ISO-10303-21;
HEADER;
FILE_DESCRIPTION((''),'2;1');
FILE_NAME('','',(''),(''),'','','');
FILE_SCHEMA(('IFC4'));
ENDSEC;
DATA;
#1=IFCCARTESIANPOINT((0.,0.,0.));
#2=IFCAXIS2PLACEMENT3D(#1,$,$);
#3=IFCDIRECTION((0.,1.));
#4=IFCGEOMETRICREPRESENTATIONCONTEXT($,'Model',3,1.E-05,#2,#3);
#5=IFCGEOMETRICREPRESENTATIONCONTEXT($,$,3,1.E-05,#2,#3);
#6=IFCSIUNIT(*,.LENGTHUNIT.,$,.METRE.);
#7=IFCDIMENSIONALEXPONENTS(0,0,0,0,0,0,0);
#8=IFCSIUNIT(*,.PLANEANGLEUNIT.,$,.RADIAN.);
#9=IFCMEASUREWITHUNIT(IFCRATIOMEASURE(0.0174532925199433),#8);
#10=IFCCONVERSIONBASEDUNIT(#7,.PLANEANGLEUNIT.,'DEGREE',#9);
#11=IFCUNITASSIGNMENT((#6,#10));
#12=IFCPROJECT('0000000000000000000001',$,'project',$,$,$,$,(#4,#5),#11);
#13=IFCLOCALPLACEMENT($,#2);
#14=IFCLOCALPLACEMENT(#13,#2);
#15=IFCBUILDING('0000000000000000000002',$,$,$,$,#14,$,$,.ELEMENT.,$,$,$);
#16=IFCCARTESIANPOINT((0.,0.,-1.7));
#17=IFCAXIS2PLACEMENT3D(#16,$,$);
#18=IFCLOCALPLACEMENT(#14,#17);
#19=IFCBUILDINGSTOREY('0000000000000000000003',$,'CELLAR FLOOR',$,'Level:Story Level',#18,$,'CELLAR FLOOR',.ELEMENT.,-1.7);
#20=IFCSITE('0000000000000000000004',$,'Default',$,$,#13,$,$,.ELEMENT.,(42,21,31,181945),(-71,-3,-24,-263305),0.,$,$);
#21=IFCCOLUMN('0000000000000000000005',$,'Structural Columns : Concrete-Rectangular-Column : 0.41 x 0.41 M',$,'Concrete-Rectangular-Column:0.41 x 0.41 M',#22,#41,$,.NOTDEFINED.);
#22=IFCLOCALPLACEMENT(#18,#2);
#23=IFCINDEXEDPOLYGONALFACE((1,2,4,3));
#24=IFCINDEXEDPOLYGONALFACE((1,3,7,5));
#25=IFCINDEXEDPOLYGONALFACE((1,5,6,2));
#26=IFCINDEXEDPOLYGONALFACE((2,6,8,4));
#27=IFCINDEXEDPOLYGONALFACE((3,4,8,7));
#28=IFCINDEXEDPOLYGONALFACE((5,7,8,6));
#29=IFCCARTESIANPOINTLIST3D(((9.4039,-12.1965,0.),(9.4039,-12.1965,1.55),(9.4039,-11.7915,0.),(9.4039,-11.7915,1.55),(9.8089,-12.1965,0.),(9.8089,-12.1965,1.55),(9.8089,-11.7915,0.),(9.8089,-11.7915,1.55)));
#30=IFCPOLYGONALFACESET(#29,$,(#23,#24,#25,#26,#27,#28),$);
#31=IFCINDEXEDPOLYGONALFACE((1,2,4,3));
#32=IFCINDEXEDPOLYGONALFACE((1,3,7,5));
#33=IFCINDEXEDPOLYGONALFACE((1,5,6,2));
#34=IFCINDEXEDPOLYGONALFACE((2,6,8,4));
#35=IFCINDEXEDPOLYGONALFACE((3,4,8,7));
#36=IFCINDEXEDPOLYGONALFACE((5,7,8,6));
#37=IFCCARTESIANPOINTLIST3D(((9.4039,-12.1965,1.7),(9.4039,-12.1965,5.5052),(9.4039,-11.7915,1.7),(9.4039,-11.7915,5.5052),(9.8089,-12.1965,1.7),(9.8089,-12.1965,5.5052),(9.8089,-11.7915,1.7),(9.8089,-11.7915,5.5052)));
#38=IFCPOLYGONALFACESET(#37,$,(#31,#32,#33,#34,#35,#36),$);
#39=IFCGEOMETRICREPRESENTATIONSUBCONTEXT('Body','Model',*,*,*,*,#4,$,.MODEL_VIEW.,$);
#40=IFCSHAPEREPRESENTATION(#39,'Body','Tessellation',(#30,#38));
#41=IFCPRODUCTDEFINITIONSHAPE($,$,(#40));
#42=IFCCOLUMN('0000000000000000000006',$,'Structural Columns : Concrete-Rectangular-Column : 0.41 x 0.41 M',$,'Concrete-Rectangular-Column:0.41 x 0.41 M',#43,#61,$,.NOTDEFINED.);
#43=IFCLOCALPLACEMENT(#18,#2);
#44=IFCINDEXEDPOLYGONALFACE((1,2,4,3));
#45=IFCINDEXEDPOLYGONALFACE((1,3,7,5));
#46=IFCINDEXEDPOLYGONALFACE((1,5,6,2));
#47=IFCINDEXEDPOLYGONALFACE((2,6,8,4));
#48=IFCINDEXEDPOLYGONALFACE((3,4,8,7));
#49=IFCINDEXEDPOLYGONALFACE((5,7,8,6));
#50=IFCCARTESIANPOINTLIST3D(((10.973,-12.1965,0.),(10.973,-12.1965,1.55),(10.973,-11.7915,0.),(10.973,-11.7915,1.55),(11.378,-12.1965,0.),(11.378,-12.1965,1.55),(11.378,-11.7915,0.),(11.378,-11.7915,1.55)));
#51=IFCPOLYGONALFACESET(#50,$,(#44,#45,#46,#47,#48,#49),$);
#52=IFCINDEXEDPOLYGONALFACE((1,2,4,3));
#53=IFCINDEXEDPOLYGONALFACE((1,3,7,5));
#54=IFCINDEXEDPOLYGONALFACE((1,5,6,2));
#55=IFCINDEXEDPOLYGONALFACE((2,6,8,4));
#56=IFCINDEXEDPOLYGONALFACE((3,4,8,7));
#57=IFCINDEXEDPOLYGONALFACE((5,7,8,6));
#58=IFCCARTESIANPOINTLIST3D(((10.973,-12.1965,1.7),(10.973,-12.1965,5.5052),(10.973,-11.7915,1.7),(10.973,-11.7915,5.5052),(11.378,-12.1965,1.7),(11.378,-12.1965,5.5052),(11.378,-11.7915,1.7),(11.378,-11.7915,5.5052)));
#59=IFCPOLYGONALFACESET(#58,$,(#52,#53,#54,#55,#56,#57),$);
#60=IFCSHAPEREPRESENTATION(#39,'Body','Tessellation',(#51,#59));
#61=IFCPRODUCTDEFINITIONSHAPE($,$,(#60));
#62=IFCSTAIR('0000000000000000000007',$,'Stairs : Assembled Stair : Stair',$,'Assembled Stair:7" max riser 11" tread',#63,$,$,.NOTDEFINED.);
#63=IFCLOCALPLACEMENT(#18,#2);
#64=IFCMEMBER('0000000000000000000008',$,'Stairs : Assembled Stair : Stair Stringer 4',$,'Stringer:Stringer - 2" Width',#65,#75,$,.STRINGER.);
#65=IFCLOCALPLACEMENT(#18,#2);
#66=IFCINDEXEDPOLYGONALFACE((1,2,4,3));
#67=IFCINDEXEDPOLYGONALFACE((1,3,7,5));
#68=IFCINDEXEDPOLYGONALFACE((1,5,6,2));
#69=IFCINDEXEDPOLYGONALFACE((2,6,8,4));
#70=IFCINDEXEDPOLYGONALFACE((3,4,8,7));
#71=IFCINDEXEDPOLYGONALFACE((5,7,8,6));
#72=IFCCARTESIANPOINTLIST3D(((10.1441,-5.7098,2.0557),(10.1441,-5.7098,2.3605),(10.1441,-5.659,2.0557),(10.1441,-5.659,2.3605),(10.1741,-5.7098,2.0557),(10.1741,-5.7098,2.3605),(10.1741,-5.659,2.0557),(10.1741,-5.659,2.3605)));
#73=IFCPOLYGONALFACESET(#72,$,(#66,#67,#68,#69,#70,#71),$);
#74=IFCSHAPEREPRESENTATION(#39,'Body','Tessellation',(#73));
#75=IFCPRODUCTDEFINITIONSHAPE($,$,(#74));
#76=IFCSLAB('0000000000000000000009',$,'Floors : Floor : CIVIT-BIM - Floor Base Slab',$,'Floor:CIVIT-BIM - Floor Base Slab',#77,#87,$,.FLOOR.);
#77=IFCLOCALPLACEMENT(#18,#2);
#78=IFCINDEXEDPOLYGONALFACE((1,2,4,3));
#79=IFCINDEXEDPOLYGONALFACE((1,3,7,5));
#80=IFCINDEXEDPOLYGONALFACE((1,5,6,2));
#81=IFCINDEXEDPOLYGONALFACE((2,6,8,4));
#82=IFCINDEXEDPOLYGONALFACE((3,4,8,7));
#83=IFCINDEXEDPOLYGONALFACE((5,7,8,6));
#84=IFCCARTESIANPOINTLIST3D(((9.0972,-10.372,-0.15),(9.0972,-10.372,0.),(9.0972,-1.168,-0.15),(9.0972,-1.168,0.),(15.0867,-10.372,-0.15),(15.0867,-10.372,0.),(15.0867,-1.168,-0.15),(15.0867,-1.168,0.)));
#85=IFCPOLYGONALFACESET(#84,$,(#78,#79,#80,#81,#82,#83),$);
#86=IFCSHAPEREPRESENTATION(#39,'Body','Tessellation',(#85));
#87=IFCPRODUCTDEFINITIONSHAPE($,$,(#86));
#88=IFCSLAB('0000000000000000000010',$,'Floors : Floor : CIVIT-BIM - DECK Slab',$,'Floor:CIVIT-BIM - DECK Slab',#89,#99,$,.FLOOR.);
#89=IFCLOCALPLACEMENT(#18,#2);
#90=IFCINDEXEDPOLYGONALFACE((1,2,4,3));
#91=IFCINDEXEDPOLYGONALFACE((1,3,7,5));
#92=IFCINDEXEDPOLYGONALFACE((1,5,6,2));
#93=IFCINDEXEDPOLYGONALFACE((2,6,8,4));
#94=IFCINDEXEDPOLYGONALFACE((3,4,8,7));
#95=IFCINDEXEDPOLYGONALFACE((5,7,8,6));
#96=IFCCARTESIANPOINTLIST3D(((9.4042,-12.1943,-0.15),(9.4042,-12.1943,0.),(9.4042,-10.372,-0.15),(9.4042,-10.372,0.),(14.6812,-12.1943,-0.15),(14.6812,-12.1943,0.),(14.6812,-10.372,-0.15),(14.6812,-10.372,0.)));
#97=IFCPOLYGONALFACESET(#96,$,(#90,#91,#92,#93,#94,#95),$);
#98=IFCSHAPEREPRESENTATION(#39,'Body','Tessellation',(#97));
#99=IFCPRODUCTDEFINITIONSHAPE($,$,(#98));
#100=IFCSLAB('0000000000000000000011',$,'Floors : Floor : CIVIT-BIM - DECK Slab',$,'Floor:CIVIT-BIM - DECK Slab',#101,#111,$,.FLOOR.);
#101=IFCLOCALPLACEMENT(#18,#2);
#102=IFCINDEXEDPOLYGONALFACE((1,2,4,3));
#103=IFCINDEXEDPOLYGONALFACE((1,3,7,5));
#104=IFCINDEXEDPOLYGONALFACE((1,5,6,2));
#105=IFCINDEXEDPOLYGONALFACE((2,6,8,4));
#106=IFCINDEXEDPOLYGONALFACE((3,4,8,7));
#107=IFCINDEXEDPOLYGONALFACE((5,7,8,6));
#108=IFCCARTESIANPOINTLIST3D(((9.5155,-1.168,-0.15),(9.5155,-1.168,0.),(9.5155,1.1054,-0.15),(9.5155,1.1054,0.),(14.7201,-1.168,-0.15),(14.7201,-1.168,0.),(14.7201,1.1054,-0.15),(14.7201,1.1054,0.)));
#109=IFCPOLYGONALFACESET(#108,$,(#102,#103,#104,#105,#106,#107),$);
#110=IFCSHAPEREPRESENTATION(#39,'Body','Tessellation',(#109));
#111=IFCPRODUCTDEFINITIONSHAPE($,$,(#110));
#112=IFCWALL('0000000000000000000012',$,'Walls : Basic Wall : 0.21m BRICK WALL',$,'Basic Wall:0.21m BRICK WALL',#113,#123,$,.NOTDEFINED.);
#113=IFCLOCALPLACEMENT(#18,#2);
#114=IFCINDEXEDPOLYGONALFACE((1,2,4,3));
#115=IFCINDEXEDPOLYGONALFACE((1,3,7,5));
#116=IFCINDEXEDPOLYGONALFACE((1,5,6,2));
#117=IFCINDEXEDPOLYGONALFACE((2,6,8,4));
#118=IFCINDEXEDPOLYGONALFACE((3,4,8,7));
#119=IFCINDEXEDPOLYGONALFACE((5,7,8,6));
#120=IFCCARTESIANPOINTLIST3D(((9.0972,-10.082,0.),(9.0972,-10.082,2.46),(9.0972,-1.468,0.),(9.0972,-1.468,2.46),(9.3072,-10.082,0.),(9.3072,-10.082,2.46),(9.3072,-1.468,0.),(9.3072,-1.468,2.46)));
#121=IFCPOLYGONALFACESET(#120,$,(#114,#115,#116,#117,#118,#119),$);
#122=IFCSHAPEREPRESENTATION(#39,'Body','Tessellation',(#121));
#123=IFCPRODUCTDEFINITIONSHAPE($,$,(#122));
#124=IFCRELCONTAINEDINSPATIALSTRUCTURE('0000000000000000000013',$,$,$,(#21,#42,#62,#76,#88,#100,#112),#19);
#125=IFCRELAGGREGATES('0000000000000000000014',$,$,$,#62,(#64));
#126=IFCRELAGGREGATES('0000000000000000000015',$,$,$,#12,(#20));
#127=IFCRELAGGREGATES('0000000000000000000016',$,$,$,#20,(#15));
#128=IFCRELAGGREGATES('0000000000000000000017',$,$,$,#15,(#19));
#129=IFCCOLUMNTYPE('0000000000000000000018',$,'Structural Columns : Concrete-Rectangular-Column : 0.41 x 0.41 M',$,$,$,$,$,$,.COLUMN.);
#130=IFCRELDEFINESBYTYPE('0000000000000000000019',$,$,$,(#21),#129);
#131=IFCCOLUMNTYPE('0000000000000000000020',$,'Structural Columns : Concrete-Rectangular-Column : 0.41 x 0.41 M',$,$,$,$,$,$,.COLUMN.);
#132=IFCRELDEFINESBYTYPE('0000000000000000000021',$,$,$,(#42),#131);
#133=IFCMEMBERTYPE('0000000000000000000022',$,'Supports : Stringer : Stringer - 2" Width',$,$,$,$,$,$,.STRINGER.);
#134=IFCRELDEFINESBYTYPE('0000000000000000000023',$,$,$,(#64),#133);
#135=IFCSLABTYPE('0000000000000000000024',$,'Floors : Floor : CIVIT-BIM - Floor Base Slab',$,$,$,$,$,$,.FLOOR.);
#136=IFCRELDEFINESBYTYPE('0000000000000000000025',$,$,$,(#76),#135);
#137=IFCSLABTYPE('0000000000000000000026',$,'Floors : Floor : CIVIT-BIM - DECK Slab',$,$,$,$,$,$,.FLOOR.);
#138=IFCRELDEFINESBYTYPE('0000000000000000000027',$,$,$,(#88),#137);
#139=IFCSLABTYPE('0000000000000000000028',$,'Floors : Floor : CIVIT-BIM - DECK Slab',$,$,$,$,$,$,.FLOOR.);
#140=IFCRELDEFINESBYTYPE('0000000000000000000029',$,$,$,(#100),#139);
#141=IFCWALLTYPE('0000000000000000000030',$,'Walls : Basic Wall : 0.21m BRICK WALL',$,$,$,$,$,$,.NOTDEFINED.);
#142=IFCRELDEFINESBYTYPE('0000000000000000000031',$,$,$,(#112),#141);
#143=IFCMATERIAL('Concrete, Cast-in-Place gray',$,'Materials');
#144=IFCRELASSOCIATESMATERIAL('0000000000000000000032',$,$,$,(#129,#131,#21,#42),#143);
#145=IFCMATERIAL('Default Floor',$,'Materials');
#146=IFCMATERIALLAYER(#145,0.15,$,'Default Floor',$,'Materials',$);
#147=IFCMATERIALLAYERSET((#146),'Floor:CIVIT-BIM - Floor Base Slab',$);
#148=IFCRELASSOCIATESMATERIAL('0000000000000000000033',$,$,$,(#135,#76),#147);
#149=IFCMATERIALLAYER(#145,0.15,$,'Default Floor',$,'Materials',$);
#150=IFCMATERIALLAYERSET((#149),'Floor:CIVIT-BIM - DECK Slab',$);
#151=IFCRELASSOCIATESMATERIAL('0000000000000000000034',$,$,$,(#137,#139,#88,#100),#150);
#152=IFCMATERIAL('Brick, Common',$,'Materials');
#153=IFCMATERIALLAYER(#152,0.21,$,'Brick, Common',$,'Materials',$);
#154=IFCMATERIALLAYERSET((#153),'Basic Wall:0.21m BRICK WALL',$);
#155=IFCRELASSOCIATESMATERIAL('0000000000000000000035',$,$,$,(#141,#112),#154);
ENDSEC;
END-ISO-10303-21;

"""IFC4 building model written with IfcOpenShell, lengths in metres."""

from ifc_helpers import new_model, entity, si_unit, converted_unit, direction, frame, frame_2d, origin, origin_2d_with_axis, place, context, subcontext, project, spatial, rectangle, extrude, source, transform, mapped, material, layer, layer_set, layer_usage, material_profile, profile_set, profile_usage, type_object, type_shapes, element, aggregate, save


model = new_model("IFC4")

# Units and contexts
model_context = context("Model", 3, precision=1e-05, world=origin(), true_north=direction((0.0, 1.0)))
context_of_model = context(None, 3, precision=1e-05, world=origin(), true_north=direction((0.0, 1.0)))
body_context = subcontext(model_context, "Body", "Model", "MODEL_VIEW")
ifc_project = project(units=[si_unit("LENGTHUNIT", "METRE"), converted_unit("PLANEANGLEUNIT", "DEGREE", entity("IfcRatioMeasure", 0.0174532925199433), si_unit("PLANEANGLEUNIT", "RADIAN"), dimensions=[0, 0, 0, 0, 0, 0, 0])], contexts=[model_context, context_of_model])

# Site, building, storey
site_placement = place(None, origin())
site = spatial("IfcSite", under=ifc_project, at=site_placement, Name="Default", CompositionType="ELEMENT", RefLatitude=(42, 21, 31, 181945), RefLongitude=(-71, -3, -24, -263305), RefElevation=0.0)
building_placement = place(site_placement, origin())
building = spatial("IfcBuilding", under=site, at=building_placement, CompositionType="ELEMENT")
storey_placement = place(building_placement, frame((0.0, 0.0, -1.7)))
storey = spatial("IfcBuildingStorey", under=building, at=storey_placement, Name="CELLAR FLOOR", ObjectType="Level:Story Level", LongName="CELLAR FLOOR", CompositionType="ELEMENT", Elevation=-1.7)

# Columns
ifc_material_1 = material(Name="Concrete, Cast-in-Place gray", Category="Materials")
ifc_material_profile = material_profile(ifc_material_1, rectangle(XDim=0.405, YDim=0.405, at=frame_2d((0.0, 0.0), x_axis=(1.0, 0.0))), Name="0.41 x 0.41 M")
ifc_profile_set = profile_set([ifc_material_profile], Name="0.41 x 0.41 M")
ifc_profile_usage_1 = profile_usage(ifc_profile_set)
column_type_1 = type_object("IfcColumnType", Name="Structural Columns : Concrete-Rectangular-Column : 0.41 x 0.41 M", PredefinedType="COLUMN", material=ifc_profile_set)
shared_shape_1 = source(origin(), body_context, "Body", "SweptSolid", [
    extrude(rectangle(XDim=0.405, YDim=0.405, at=frame_2d((0.0, 0.0), x_axis=(1.0, 0.0))), frame((9.6064, -11.994, -1.7), z_axis=(0.0, 0.0, 1.0), x_axis=(0.0, -1.0, 0.0)), (0.0, 0.0, 1.0), 1.55),
    extrude(rectangle(XDim=0.405, YDim=0.405, at=frame_2d((0.0, 0.0), x_axis=(1.0, 0.0))), frame((9.6064, -11.994, 0.0), z_axis=(0.0, 0.0, 1.0), x_axis=(0.0, -1.0, 0.0)), (0.0, 0.0, 1.0), 3.8052),
])
type_shapes(column_type_1, [shared_shape_1])
column_1_placement = place(storey_placement, frame((0.0, 0.0, 1.7)))
element("IfcColumn", 1, at=column_1_placement, inside=storey, type_object=column_type_1, material=ifc_profile_usage_1, Name="Structural Columns : Concrete-Rectangular-Column : 0.41 x 0.41 M", ObjectType="Concrete-Rectangular-Column:0.41 x 0.41 M", PredefinedType="NOTDEFINED", context=body_context, shape_type="MappedRepresentation", body=[
    mapped(shared_shape_1, transform((0.0, 0.0, 0.0), scale=1.0)),
])
ifc_profile_usage_2 = profile_usage(ifc_profile_set)
column_type_2 = type_object("IfcColumnType", Name="Structural Columns : Concrete-Rectangular-Column : 0.41 x 0.41 M", PredefinedType="COLUMN", material=ifc_profile_set)
shared_shape_2 = source(origin(), body_context, "Body", "SweptSolid", [
    extrude(rectangle(XDim=0.405, YDim=0.405, at=origin_2d_with_axis()), frame((11.1755, -11.994, -1.7), z_axis=(0.0, 0.0, 1.0), x_axis=(0.0, -1.0, 0.0)), (0.0, 0.0, 1.0), 1.55),
    extrude(rectangle(XDim=0.405, YDim=0.405, at=origin_2d_with_axis()), frame((11.1755, -11.994, 0.0), z_axis=(0.0, 0.0, 1.0), x_axis=(0.0, -1.0, 0.0)), (0.0, 0.0, 1.0), 3.8052),
])
type_shapes(column_type_2, [shared_shape_2])
column_2_placement = place(storey_placement, frame((0.0, 0.0, 1.7)))
element("IfcColumn", 2, at=column_2_placement, inside=storey, type_object=column_type_2, material=ifc_profile_usage_2, Name="Structural Columns : Concrete-Rectangular-Column : 0.41 x 0.41 M", ObjectType="Concrete-Rectangular-Column:0.41 x 0.41 M", PredefinedType="NOTDEFINED", context=body_context, shape_type="MappedRepresentation", body=[
    mapped(shared_shape_2, transform((0.0, 0.0, 0.0), scale=1.0)),
])

# Stair, member
stair_1_placement = place(storey_placement, origin())
stair_1 = element("IfcStair", 3, at=stair_1_placement, inside=storey, Name="Stairs : Assembled Stair : Stair", ObjectType="Assembled Stair:7\" max riser 11\" tread", PredefinedType="NOTDEFINED")
member_type = type_object("IfcMemberType", Name="Supports : Stringer : Stringer - 2\" Width", PredefinedType="STRINGER")
member_1_placement = place(stair_1_placement, frame((10.1441, -5.7098, 2.0557)))
member_1 = element("IfcMember", 4, at=member_1_placement, type_object=member_type, Name="Stairs : Assembled Stair : Stair Stringer 4", ObjectType="Stringer:Stringer - 2\" Width", PredefinedType="STRINGER", context=body_context, shape_type="SweptSolid", body=[
    extrude(rectangle(XDim=0.03, YDim=0.0508, at=frame_2d((0.0, 0.0), x_axis=(1.0, 0.0))), frame((0.015, 0.0254, 0.0)), (0.0, 0.0, 1.0), 0.3048),
])
aggregate(stair_1, [member_1])

# Slabs
ifc_material_2 = material(Name="Default Floor", Category="Materials")
ifc_layer_1 = layer(ifc_material_2, 0.15, Name="Default Floor", Category="Materials")
ifc_layer_set_1 = layer_set([ifc_layer_1], Name="Floor:CIVIT-BIM - Floor Base Slab")
ifc_layer_usage_1 = layer_usage(ifc_layer_set_1, "AXIS3", "POSITIVE", 0.0)
slab_type_1 = type_object("IfcSlabType", Name="Floors : Floor : CIVIT-BIM - Floor Base Slab", PredefinedType="FLOOR", material=ifc_layer_set_1)
slab_1_placement = place(storey_placement, origin())
element("IfcSlab", 5, at=slab_1_placement, inside=storey, type_object=slab_type_1, material=ifc_layer_usage_1, Name="Floors : Floor : CIVIT-BIM - Floor Base Slab", ObjectType="Floor:CIVIT-BIM - Floor Base Slab", PredefinedType="FLOOR", context=body_context, shape_type="SweptSolid", body=[
    extrude(rectangle(XDim=9.204, YDim=5.9894, at=frame_2d((0.0, 0.0), x_axis=(1.0, 0.0))), frame((12.0919, -5.77, 0.0), z_axis=(0.0, 0.0, -1.0), x_axis=(0.0, 1.0, 0.0)), (0.0, 0.0, 1.0), 0.15),
])
ifc_layer_2 = layer(ifc_material_2, 0.15, Name="Default Floor", Category="Materials")
ifc_layer_set_2 = layer_set([ifc_layer_2], Name="Floor:CIVIT-BIM - DECK Slab")
ifc_layer_usage_2 = layer_usage(ifc_layer_set_2, "AXIS3", "POSITIVE", 0.0)
slab_type_2 = type_object("IfcSlabType", Name="Floors : Floor : CIVIT-BIM - DECK Slab", PredefinedType="FLOOR", material=ifc_layer_set_2)
slab_2_placement = place(storey_placement, origin())
element("IfcSlab", 6, at=slab_2_placement, inside=storey, type_object=slab_type_2, material=ifc_layer_usage_2, Name="Floors : Floor : CIVIT-BIM - DECK Slab", ObjectType="Floor:CIVIT-BIM - DECK Slab", PredefinedType="FLOOR", context=body_context, shape_type="SweptSolid", body=[
    extrude(rectangle(XDim=1.8223, YDim=5.277, at=frame_2d((0.0, 0.0), x_axis=(1.0, 0.0))), frame((12.0427, -11.2831, 0.0), z_axis=(0.0, 0.0, -1.0), x_axis=(0.0, 1.0, 0.0)), (0.0, 0.0, 1.0), 0.15),
])
ifc_layer_usage_3 = layer_usage(ifc_layer_set_2, "AXIS3", "POSITIVE", 0.0)
slab_type_3 = type_object("IfcSlabType", Name="Floors : Floor : CIVIT-BIM - DECK Slab", PredefinedType="FLOOR", material=ifc_layer_set_2)
slab_3_placement = place(storey_placement, origin())
element("IfcSlab", 7, at=slab_3_placement, inside=storey, type_object=slab_type_3, material=ifc_layer_usage_3, Name="Floors : Floor : CIVIT-BIM - DECK Slab", ObjectType="Floor:CIVIT-BIM - DECK Slab", PredefinedType="FLOOR", context=body_context, shape_type="SweptSolid", body=[
    extrude(rectangle(XDim=2.2734, YDim=5.2046, at=origin_2d_with_axis()), frame((12.1178, -0.0313, 0.0), z_axis=(0.0, 0.0, -1.0), x_axis=(0.0, 1.0, 0.0)), (0.0, 0.0, 1.0), 0.15),
])

# Wall
ifc_material_3 = material(Name="Brick, Common", Category="Materials")
ifc_layer_3 = layer(ifc_material_3, 0.21, Name="Brick, Common", Category="Materials")
ifc_layer_set_3 = layer_set([ifc_layer_3], Name="Basic Wall:0.21m BRICK WALL")
ifc_layer_usage_4 = layer_usage(ifc_layer_set_3, "AXIS2", "NEGATIVE", 0.105)
wall_type_1 = type_object("IfcWallType", Name="Walls : Basic Wall : 0.21m BRICK WALL", PredefinedType="NOTDEFINED", material=ifc_layer_set_3)
wall_1_placement = place(storey_placement, frame((9.2022, -10.082, 0.0), z_axis=(0.0, 0.0, 1.0), x_axis=(0.0, 1.0, 0.0)))
element("IfcWall", 8, at=wall_1_placement, inside=storey, type_object=wall_type_1, material=ifc_layer_usage_4, Name="Walls : Basic Wall : 0.21m BRICK WALL", ObjectType="Basic Wall:0.21m BRICK WALL", PredefinedType="NOTDEFINED", context=body_context, shape_type="SweptSolid", body=[
    extrude(rectangle(XDim=8.614, YDim=0.21, at=frame_2d((4.307, 0.0), x_axis=(-1.0, 0.0))), origin(), (0.0, 0.0, 1.0), 2.46),
])

save(model, "model.ifc")
